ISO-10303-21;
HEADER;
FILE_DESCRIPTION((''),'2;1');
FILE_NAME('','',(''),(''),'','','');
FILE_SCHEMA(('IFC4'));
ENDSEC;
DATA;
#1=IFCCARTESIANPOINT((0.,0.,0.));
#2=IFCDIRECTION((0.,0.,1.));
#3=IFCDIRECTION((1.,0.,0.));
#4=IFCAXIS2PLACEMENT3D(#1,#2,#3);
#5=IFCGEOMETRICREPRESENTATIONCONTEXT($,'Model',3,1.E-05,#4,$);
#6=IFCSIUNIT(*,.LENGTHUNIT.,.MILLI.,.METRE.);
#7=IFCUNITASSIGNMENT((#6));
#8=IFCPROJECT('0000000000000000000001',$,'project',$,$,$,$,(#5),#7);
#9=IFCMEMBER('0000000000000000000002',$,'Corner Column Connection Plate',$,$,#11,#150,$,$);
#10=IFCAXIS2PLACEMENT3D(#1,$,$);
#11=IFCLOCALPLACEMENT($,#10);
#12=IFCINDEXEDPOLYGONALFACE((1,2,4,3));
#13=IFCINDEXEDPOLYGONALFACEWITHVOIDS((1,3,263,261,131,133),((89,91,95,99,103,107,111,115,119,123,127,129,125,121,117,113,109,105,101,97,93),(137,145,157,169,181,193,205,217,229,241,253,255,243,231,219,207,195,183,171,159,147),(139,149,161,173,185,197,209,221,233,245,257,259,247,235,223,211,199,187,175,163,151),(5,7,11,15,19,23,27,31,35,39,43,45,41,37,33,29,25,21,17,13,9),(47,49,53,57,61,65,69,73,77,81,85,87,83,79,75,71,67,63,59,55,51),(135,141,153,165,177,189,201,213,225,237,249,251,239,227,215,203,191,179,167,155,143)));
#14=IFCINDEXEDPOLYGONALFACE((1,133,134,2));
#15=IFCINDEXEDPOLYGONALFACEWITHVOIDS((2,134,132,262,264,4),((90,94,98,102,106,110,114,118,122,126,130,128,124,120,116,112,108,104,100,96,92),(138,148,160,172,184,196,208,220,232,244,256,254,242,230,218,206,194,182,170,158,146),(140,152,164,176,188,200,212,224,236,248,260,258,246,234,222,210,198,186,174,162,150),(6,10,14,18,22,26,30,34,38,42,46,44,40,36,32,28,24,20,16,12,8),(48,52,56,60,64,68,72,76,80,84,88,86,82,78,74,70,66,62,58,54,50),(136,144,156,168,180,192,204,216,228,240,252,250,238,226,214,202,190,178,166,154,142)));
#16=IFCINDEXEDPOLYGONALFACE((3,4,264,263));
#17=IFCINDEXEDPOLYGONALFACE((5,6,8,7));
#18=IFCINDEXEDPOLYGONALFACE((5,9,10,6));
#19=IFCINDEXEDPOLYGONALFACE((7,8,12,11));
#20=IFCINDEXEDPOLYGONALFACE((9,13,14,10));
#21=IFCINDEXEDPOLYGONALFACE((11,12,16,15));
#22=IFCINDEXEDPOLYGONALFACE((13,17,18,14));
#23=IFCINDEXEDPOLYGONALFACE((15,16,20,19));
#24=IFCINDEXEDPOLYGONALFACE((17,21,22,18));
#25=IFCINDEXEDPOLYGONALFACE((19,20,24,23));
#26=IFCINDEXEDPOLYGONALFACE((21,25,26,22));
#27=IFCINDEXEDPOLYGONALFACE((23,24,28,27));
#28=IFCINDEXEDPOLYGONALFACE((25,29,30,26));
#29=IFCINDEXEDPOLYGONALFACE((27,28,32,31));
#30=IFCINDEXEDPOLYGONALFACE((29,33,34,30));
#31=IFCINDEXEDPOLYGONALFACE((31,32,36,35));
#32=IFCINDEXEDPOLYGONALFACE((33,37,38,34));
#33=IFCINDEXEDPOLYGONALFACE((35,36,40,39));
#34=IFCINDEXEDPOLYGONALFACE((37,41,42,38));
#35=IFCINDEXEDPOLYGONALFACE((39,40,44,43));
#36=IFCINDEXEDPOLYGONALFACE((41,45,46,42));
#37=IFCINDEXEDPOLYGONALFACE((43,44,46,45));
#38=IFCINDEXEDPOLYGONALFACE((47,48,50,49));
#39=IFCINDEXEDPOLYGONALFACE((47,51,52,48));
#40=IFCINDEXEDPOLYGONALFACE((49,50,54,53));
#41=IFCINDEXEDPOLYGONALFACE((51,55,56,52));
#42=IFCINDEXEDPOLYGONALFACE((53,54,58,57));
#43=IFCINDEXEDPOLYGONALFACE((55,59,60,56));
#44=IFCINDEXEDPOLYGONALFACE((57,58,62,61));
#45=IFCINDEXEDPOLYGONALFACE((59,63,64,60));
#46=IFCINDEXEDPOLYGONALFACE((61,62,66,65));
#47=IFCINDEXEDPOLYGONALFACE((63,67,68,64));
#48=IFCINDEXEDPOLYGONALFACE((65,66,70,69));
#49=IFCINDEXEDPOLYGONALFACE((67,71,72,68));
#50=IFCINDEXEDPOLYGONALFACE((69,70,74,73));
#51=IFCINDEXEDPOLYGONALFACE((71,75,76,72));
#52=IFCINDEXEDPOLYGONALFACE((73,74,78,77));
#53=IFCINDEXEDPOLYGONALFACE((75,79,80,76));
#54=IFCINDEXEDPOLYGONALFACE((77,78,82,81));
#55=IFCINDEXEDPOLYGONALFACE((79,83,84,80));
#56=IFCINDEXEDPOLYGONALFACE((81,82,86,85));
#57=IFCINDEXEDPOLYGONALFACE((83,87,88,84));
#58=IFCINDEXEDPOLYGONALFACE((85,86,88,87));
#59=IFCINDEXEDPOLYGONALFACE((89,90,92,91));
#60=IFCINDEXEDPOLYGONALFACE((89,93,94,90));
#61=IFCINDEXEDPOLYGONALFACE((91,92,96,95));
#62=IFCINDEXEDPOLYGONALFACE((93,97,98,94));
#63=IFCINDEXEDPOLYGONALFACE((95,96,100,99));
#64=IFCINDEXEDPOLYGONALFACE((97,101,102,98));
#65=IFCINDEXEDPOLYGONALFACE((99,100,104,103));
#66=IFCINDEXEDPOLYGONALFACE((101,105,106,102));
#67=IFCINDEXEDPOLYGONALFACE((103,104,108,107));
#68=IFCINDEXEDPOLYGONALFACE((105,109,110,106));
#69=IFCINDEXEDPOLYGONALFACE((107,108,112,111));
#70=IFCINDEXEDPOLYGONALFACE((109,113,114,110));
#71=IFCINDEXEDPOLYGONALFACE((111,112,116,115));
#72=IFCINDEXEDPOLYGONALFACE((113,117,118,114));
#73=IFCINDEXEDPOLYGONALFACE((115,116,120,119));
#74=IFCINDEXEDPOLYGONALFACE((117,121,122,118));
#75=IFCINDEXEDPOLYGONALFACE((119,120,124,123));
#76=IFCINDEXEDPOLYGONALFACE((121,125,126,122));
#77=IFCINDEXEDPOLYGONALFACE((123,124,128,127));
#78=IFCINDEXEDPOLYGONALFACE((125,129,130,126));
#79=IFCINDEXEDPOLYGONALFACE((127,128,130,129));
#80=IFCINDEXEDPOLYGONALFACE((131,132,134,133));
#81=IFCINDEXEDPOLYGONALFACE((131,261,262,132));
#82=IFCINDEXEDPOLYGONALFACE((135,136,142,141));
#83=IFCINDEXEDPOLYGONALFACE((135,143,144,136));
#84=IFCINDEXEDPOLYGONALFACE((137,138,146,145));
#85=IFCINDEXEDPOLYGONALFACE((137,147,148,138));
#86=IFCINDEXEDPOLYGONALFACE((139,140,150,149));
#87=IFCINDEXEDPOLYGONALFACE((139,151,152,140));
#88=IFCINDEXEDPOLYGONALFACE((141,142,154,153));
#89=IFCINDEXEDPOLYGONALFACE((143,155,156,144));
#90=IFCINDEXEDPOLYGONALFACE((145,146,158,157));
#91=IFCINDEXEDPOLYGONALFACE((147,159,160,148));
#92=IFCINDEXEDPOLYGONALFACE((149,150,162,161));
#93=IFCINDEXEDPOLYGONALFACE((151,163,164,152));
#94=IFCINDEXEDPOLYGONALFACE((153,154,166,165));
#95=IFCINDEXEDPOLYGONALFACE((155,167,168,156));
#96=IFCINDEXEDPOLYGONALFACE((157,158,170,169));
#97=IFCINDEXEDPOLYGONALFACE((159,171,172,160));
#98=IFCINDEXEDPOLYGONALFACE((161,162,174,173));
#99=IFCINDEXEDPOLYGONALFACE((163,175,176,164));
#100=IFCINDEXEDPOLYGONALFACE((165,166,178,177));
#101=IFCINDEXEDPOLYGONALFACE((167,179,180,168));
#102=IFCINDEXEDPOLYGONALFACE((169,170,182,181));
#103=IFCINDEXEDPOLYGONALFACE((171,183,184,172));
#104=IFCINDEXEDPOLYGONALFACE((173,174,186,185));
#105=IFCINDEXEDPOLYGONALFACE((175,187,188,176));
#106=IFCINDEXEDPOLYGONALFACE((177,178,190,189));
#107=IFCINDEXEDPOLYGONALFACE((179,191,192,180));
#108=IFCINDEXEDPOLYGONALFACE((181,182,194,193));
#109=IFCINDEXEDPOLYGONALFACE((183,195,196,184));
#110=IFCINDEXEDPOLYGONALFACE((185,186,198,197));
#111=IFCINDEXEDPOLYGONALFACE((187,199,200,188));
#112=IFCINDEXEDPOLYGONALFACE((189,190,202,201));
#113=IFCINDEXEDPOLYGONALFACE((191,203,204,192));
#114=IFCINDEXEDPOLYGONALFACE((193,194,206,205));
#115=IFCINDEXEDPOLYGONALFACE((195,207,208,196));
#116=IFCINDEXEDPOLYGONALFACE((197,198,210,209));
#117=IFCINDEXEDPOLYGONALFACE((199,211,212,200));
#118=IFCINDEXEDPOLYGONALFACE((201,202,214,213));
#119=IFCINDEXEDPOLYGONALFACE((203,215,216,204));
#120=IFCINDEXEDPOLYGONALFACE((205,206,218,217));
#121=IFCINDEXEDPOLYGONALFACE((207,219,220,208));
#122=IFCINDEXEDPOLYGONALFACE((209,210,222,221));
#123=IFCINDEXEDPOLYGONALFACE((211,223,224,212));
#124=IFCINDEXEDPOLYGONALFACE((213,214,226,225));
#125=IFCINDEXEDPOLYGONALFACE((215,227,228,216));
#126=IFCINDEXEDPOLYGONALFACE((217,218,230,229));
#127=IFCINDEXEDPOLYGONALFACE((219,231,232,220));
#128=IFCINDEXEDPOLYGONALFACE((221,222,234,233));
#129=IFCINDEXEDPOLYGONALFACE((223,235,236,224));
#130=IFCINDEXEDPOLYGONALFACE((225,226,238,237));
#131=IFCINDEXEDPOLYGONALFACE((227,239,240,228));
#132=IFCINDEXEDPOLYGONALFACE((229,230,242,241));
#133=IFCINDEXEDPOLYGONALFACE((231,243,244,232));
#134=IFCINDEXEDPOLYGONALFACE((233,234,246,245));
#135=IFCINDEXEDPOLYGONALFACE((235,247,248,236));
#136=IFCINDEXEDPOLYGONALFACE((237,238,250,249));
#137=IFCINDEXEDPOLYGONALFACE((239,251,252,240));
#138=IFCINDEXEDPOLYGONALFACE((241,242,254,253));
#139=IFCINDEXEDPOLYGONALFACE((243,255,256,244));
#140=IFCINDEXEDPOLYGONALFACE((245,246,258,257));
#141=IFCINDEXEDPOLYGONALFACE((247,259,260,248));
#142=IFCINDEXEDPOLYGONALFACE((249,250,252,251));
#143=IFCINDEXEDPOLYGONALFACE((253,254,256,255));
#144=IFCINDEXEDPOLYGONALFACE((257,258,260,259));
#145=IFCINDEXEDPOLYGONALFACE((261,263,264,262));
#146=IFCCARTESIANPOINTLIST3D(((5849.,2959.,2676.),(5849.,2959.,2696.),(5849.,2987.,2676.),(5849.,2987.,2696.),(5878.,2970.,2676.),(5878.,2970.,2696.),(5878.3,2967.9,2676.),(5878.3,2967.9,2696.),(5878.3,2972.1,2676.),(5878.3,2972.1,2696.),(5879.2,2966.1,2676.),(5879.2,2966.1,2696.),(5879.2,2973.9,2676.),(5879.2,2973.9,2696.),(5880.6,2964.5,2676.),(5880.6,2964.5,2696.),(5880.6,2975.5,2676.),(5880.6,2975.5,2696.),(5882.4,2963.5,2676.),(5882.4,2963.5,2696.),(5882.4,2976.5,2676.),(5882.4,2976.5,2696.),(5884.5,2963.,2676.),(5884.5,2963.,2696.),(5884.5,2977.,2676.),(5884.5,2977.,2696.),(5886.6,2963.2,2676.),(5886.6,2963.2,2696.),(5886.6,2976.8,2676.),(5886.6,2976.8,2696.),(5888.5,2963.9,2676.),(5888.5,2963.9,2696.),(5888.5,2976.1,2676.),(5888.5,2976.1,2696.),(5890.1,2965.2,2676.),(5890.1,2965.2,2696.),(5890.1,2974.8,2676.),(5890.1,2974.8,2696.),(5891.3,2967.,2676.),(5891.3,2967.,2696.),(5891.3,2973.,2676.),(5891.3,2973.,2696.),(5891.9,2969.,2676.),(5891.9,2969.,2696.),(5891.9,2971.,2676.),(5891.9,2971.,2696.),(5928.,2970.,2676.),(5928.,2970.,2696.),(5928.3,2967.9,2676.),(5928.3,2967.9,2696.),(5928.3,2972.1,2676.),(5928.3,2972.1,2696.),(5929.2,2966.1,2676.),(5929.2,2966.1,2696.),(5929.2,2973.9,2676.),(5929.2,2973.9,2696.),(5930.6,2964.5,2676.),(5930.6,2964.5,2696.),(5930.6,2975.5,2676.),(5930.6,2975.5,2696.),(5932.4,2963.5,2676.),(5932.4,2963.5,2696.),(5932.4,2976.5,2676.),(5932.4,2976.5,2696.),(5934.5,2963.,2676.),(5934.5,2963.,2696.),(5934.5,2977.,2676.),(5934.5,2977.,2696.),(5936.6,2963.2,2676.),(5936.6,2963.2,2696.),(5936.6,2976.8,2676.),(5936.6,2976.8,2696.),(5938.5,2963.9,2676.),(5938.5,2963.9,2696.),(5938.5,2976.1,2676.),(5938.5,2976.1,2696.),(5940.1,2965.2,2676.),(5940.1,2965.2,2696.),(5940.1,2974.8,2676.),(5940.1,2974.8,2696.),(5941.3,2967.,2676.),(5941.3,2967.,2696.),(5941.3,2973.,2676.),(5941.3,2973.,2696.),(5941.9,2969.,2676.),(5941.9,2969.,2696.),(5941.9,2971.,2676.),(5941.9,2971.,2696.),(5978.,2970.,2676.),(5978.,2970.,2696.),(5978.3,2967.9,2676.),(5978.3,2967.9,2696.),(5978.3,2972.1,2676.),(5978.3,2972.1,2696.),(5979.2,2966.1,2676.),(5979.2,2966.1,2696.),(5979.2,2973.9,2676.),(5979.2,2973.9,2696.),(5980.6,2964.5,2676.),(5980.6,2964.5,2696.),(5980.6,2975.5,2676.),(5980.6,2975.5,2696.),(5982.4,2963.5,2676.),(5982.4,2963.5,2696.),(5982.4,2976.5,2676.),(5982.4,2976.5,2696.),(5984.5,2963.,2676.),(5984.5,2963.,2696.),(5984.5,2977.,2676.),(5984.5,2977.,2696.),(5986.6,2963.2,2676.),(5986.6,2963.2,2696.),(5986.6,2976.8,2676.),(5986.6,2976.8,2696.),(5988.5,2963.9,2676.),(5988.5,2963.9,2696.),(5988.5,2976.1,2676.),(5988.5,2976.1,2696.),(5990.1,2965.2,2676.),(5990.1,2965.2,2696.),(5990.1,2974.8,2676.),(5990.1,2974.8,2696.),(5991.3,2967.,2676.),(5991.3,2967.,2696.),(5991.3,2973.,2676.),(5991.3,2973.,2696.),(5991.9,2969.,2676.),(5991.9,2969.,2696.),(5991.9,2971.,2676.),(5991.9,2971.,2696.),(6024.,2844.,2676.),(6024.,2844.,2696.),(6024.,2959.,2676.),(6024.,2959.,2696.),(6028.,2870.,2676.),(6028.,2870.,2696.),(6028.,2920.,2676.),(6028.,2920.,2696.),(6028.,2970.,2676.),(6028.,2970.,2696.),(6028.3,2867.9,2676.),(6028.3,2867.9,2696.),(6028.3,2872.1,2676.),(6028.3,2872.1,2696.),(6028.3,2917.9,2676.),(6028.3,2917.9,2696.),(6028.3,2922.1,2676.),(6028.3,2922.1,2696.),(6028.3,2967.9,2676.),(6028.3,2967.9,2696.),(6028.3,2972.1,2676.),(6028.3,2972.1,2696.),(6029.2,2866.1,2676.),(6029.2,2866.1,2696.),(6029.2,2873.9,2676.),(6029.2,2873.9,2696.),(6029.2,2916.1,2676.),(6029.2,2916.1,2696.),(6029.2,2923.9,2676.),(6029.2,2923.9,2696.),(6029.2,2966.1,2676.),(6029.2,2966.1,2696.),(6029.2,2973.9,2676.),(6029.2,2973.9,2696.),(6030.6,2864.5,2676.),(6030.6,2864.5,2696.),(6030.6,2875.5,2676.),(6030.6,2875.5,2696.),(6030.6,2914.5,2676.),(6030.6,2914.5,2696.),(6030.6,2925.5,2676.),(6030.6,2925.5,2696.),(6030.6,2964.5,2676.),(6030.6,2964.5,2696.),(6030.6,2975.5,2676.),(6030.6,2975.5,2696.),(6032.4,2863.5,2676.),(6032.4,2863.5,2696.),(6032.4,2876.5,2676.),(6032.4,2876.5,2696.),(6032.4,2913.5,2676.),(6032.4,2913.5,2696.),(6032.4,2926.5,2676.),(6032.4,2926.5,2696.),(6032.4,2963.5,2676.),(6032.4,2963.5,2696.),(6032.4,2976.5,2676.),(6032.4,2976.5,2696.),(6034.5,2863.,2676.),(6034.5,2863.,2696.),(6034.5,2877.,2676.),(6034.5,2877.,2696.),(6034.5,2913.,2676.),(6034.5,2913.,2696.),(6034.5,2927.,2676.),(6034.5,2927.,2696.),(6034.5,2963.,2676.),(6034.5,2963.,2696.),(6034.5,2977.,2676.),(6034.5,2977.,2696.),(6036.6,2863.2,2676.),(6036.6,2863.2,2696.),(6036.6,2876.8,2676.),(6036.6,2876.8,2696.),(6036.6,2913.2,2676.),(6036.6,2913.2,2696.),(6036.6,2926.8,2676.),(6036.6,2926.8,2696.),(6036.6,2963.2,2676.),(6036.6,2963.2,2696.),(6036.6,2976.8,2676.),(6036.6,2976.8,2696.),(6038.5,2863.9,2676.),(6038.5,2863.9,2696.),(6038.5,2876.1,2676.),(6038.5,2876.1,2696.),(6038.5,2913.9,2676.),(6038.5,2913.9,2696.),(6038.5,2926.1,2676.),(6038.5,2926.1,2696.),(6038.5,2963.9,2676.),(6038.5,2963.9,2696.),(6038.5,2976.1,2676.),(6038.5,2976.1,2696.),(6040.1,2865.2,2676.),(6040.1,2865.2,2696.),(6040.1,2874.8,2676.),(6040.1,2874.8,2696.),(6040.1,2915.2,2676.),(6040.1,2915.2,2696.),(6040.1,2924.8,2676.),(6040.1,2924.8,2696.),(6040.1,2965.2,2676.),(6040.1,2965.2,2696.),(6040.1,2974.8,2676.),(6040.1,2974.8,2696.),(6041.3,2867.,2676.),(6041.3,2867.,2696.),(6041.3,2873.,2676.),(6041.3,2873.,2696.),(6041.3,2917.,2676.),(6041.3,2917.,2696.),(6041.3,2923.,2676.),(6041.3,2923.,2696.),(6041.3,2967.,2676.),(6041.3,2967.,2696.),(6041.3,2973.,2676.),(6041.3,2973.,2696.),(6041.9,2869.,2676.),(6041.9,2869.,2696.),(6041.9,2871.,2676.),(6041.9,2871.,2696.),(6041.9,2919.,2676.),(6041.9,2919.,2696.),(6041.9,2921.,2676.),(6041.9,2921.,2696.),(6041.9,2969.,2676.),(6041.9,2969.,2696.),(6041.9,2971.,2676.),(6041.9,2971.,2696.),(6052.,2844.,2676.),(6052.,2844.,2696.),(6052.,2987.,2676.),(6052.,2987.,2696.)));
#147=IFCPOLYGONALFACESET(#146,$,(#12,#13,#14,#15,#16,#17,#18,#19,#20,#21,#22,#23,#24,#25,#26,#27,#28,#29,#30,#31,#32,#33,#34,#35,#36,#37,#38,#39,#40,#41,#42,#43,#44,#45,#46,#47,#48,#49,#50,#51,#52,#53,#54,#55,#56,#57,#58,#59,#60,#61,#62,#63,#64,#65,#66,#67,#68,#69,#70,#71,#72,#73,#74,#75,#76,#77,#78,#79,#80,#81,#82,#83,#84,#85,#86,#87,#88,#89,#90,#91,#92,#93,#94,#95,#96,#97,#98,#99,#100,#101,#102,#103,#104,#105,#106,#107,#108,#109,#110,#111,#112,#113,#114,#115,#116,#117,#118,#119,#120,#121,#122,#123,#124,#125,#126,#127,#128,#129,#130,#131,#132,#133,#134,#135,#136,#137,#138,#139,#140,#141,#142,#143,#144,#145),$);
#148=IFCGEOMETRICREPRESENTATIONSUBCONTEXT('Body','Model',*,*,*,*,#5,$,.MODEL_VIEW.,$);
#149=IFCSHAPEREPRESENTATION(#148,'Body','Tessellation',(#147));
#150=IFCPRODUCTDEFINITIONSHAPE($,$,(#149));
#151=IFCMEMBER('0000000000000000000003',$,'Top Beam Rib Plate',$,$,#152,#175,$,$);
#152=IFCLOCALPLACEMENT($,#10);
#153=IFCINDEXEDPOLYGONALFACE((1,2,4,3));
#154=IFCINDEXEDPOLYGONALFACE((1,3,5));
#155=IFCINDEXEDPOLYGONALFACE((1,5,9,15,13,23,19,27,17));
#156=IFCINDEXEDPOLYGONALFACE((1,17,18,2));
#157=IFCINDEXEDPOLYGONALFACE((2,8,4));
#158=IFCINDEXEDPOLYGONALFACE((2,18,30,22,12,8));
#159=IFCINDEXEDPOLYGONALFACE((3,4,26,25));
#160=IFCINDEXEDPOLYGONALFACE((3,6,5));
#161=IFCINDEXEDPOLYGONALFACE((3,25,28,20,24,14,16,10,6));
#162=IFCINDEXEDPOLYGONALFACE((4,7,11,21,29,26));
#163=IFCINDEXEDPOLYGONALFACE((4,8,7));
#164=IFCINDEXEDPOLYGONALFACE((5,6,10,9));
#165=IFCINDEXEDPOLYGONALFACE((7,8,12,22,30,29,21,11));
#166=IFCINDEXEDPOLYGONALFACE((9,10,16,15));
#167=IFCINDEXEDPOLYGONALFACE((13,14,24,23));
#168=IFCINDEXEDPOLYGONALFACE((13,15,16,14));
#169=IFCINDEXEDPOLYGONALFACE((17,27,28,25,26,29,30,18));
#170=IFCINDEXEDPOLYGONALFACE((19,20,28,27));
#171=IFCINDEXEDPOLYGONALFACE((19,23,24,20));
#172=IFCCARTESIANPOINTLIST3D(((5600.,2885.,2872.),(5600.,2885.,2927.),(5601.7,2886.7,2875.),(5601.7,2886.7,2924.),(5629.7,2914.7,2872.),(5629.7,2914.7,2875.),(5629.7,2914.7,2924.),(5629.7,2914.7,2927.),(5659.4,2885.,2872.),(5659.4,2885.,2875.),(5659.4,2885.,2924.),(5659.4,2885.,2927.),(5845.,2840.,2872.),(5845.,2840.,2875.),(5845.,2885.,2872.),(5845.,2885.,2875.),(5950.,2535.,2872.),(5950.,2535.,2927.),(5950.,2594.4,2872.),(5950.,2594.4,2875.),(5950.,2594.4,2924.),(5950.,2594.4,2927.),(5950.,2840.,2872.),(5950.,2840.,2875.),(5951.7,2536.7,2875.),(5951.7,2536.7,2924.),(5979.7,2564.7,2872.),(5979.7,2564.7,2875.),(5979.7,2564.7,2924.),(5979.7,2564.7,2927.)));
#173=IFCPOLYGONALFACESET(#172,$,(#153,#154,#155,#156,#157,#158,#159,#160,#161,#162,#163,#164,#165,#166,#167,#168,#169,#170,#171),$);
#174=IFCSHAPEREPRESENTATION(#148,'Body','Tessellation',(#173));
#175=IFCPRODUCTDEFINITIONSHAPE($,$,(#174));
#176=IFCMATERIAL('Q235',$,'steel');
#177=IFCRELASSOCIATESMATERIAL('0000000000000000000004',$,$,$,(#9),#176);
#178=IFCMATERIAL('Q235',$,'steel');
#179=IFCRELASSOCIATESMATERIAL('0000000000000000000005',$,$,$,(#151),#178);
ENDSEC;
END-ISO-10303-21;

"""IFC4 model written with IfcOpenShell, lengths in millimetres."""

from ifc_helpers import new_model, si_unit, frame, origin_with_axes, origin_2d, place, context, subcontext, project, line, indexed_curve, circle_curve, outline, extrude, material, element, save


model = new_model("IFC4")

# Units and contexts
model_context = context("Model", 3, precision=1e-05, world=origin_with_axes())
body_context = subcontext(model_context, "Body", "Model", "MODEL_VIEW")
ifc_project = project(units=[si_unit("LENGTHUNIT", "METRE", prefix="MILLI")], contexts=[model_context])

# Members, openings
ifc_material_1 = material(Name="Q235", Category="steel")
member_1_placement = place(None, frame((6052.0, 2987.0, 2676.0), z_axis=(0.0, 0.0, 1.0), x_axis=(-1.0, 0.0, 0.0)))
member_1 = element("IfcMember", 1, at=member_1_placement, material=ifc_material_1, Name="Corner Column Connection Plate", context=body_context, shape_type="SweptSolid", body=[
    extrude(outline(indexed_curve([(0.0, 0.0), (203.0, 0.0), (203.0, 28.0), (28.0, 28.0), (28.0, 143.0), (0.0, 143.0), (0.0, 0.0)], segments=[line(1, 2, 3, 4, 5, 6, 7, 1)])), origin_with_axes(), (0.0, 0.0, 1.0), 20.0),
])
opening_1_placement = place(member_1_placement, frame((17.0, 17.0, 0.0), z_axis=(0.0, 0.0, 1.0), x_axis=(1.0, 0.0, 0.0)))
element("IfcOpeningElement", 2, at=opening_1_placement, cuts=member_1, context=body_context, shape_type="SweptSolid", body=[
    extrude(outline(circle_curve(origin_2d(), 7.0)), origin_with_axes(), (0.0, 0.0, 1.0), 20.0),
])
opening_2_placement = place(member_1_placement, frame((67.0, 17.0, 0.0), z_axis=(0.0, 0.0, 1.0), x_axis=(1.0, 0.0, 0.0)))
element("IfcOpeningElement", 3, at=opening_2_placement, cuts=member_1, context=body_context, shape_type="SweptSolid", body=[
    extrude(outline(circle_curve(origin_2d(), 7.0)), origin_with_axes(), (0.0, 0.0, 1.0), 20.0),
])
opening_3_placement = place(member_1_placement, frame((117.0, 17.0, 0.0), z_axis=(0.0, 0.0, 1.0), x_axis=(1.0, 0.0, 0.0)))
element("IfcOpeningElement", 4, at=opening_3_placement, cuts=member_1, context=body_context, shape_type="SweptSolid", body=[
    extrude(outline(circle_curve(origin_2d(), 7.0)), origin_with_axes(), (0.0, 0.0, 1.0), 20.0),
])
opening_4_placement = place(member_1_placement, frame((167.0, 17.0, 0.0), z_axis=(0.0, 0.0, 1.0), x_axis=(1.0, 0.0, 0.0)))
element("IfcOpeningElement", 5, at=opening_4_placement, cuts=member_1, context=body_context, shape_type="SweptSolid", body=[
    extrude(outline(circle_curve(origin_2d(), 7.0)), origin_with_axes(), (0.0, 0.0, 1.0), 20.0),
])
opening_5_placement = place(member_1_placement, frame((17.0, 67.0, 0.0), z_axis=(0.0, 0.0, 1.0), x_axis=(1.0, 0.0, 0.0)))
element("IfcOpeningElement", 6, at=opening_5_placement, cuts=member_1, context=body_context, shape_type="SweptSolid", body=[
    extrude(outline(circle_curve(origin_2d(), 7.0)), origin_with_axes(), (0.0, 0.0, 1.0), 20.0),
])
opening_6_placement = place(member_1_placement, frame((17.0, 117.0, 0.0), z_axis=(0.0, 0.0, 1.0), x_axis=(1.0, 0.0, 0.0)))
element("IfcOpeningElement", 7, at=opening_6_placement, cuts=member_1, context=body_context, shape_type="SweptSolid", body=[
    extrude(outline(circle_curve(origin_2d(), 7.0)), origin_with_axes(), (0.0, 0.0, 1.0), 20.0),
])
ifc_material_2 = material(Name="Q235", Category="steel")
member_2_placement = place(None, frame((5845.0, 2840.0, 2872.0), z_axis=(0.0, 0.0, 1.0), x_axis=(-1.0, 0.0, 0.0)))
member_2 = element("IfcMember", 8, at=member_2_placement, material=ifc_material_2, Name="Top Beam Rib Plate", context=body_context, shape_type="SweptSolid", body=[
    extrude(outline(indexed_curve([(0.0, 0.0), (0.0, -45.0), (185.6, -45.0), (215.3, -74.7), (245.0, -45.0), (-105.0, 305.0), (-134.7, 275.3), (-105.0, 245.6), (-105.0, 0.0), (0.0, 0.0)], segments=[line(1, 2, 3, 4, 5, 6, 7, 8, 9, 10, 1)])), origin_with_axes(), (0.0, 0.0, 1.0), 55.0),
])
opening_7_placement = place(member_2_placement, frame((0.0, 0.0, 3.0), z_axis=(0.0, 0.0, 1.0), x_axis=(1.0, 0.0, 0.0)))
element("IfcOpeningElement", 9, at=opening_7_placement, cuts=member_2, context=body_context, shape_type="SweptSolid", body=[
    extrude(outline(indexed_curve([(0.0, 0.0), (0.0, -45.0), (185.6, -45.0), (-105.0, 245.6), (-105.0, 0.0), (0.0, 0.0)], segments=[line(1, 2, 3, 4, 5, 6, 1)])), origin_with_axes(), (0.0, 0.0, 1.0), 55.0),
])
opening_8_placement = place(member_2_placement, frame((0.0, 0.0, 3.0), z_axis=(0.0, 0.0, 1.0), x_axis=(1.0, 0.0, 0.0)))
element("IfcOpeningElement", 10, at=opening_8_placement, cuts=member_2, context=body_context, shape_type="SweptSolid", body=[
    extrude(outline(indexed_curve([(215.3, -74.7), (243.3, -46.7), (-106.7, 303.3), (-134.7, 275.3)], segments=[line(1, 2, 3, 4, 1)])), origin_with_axes(), (0.0, 0.0, 1.0), 49.0),
])

save(model, "model.ifc")
